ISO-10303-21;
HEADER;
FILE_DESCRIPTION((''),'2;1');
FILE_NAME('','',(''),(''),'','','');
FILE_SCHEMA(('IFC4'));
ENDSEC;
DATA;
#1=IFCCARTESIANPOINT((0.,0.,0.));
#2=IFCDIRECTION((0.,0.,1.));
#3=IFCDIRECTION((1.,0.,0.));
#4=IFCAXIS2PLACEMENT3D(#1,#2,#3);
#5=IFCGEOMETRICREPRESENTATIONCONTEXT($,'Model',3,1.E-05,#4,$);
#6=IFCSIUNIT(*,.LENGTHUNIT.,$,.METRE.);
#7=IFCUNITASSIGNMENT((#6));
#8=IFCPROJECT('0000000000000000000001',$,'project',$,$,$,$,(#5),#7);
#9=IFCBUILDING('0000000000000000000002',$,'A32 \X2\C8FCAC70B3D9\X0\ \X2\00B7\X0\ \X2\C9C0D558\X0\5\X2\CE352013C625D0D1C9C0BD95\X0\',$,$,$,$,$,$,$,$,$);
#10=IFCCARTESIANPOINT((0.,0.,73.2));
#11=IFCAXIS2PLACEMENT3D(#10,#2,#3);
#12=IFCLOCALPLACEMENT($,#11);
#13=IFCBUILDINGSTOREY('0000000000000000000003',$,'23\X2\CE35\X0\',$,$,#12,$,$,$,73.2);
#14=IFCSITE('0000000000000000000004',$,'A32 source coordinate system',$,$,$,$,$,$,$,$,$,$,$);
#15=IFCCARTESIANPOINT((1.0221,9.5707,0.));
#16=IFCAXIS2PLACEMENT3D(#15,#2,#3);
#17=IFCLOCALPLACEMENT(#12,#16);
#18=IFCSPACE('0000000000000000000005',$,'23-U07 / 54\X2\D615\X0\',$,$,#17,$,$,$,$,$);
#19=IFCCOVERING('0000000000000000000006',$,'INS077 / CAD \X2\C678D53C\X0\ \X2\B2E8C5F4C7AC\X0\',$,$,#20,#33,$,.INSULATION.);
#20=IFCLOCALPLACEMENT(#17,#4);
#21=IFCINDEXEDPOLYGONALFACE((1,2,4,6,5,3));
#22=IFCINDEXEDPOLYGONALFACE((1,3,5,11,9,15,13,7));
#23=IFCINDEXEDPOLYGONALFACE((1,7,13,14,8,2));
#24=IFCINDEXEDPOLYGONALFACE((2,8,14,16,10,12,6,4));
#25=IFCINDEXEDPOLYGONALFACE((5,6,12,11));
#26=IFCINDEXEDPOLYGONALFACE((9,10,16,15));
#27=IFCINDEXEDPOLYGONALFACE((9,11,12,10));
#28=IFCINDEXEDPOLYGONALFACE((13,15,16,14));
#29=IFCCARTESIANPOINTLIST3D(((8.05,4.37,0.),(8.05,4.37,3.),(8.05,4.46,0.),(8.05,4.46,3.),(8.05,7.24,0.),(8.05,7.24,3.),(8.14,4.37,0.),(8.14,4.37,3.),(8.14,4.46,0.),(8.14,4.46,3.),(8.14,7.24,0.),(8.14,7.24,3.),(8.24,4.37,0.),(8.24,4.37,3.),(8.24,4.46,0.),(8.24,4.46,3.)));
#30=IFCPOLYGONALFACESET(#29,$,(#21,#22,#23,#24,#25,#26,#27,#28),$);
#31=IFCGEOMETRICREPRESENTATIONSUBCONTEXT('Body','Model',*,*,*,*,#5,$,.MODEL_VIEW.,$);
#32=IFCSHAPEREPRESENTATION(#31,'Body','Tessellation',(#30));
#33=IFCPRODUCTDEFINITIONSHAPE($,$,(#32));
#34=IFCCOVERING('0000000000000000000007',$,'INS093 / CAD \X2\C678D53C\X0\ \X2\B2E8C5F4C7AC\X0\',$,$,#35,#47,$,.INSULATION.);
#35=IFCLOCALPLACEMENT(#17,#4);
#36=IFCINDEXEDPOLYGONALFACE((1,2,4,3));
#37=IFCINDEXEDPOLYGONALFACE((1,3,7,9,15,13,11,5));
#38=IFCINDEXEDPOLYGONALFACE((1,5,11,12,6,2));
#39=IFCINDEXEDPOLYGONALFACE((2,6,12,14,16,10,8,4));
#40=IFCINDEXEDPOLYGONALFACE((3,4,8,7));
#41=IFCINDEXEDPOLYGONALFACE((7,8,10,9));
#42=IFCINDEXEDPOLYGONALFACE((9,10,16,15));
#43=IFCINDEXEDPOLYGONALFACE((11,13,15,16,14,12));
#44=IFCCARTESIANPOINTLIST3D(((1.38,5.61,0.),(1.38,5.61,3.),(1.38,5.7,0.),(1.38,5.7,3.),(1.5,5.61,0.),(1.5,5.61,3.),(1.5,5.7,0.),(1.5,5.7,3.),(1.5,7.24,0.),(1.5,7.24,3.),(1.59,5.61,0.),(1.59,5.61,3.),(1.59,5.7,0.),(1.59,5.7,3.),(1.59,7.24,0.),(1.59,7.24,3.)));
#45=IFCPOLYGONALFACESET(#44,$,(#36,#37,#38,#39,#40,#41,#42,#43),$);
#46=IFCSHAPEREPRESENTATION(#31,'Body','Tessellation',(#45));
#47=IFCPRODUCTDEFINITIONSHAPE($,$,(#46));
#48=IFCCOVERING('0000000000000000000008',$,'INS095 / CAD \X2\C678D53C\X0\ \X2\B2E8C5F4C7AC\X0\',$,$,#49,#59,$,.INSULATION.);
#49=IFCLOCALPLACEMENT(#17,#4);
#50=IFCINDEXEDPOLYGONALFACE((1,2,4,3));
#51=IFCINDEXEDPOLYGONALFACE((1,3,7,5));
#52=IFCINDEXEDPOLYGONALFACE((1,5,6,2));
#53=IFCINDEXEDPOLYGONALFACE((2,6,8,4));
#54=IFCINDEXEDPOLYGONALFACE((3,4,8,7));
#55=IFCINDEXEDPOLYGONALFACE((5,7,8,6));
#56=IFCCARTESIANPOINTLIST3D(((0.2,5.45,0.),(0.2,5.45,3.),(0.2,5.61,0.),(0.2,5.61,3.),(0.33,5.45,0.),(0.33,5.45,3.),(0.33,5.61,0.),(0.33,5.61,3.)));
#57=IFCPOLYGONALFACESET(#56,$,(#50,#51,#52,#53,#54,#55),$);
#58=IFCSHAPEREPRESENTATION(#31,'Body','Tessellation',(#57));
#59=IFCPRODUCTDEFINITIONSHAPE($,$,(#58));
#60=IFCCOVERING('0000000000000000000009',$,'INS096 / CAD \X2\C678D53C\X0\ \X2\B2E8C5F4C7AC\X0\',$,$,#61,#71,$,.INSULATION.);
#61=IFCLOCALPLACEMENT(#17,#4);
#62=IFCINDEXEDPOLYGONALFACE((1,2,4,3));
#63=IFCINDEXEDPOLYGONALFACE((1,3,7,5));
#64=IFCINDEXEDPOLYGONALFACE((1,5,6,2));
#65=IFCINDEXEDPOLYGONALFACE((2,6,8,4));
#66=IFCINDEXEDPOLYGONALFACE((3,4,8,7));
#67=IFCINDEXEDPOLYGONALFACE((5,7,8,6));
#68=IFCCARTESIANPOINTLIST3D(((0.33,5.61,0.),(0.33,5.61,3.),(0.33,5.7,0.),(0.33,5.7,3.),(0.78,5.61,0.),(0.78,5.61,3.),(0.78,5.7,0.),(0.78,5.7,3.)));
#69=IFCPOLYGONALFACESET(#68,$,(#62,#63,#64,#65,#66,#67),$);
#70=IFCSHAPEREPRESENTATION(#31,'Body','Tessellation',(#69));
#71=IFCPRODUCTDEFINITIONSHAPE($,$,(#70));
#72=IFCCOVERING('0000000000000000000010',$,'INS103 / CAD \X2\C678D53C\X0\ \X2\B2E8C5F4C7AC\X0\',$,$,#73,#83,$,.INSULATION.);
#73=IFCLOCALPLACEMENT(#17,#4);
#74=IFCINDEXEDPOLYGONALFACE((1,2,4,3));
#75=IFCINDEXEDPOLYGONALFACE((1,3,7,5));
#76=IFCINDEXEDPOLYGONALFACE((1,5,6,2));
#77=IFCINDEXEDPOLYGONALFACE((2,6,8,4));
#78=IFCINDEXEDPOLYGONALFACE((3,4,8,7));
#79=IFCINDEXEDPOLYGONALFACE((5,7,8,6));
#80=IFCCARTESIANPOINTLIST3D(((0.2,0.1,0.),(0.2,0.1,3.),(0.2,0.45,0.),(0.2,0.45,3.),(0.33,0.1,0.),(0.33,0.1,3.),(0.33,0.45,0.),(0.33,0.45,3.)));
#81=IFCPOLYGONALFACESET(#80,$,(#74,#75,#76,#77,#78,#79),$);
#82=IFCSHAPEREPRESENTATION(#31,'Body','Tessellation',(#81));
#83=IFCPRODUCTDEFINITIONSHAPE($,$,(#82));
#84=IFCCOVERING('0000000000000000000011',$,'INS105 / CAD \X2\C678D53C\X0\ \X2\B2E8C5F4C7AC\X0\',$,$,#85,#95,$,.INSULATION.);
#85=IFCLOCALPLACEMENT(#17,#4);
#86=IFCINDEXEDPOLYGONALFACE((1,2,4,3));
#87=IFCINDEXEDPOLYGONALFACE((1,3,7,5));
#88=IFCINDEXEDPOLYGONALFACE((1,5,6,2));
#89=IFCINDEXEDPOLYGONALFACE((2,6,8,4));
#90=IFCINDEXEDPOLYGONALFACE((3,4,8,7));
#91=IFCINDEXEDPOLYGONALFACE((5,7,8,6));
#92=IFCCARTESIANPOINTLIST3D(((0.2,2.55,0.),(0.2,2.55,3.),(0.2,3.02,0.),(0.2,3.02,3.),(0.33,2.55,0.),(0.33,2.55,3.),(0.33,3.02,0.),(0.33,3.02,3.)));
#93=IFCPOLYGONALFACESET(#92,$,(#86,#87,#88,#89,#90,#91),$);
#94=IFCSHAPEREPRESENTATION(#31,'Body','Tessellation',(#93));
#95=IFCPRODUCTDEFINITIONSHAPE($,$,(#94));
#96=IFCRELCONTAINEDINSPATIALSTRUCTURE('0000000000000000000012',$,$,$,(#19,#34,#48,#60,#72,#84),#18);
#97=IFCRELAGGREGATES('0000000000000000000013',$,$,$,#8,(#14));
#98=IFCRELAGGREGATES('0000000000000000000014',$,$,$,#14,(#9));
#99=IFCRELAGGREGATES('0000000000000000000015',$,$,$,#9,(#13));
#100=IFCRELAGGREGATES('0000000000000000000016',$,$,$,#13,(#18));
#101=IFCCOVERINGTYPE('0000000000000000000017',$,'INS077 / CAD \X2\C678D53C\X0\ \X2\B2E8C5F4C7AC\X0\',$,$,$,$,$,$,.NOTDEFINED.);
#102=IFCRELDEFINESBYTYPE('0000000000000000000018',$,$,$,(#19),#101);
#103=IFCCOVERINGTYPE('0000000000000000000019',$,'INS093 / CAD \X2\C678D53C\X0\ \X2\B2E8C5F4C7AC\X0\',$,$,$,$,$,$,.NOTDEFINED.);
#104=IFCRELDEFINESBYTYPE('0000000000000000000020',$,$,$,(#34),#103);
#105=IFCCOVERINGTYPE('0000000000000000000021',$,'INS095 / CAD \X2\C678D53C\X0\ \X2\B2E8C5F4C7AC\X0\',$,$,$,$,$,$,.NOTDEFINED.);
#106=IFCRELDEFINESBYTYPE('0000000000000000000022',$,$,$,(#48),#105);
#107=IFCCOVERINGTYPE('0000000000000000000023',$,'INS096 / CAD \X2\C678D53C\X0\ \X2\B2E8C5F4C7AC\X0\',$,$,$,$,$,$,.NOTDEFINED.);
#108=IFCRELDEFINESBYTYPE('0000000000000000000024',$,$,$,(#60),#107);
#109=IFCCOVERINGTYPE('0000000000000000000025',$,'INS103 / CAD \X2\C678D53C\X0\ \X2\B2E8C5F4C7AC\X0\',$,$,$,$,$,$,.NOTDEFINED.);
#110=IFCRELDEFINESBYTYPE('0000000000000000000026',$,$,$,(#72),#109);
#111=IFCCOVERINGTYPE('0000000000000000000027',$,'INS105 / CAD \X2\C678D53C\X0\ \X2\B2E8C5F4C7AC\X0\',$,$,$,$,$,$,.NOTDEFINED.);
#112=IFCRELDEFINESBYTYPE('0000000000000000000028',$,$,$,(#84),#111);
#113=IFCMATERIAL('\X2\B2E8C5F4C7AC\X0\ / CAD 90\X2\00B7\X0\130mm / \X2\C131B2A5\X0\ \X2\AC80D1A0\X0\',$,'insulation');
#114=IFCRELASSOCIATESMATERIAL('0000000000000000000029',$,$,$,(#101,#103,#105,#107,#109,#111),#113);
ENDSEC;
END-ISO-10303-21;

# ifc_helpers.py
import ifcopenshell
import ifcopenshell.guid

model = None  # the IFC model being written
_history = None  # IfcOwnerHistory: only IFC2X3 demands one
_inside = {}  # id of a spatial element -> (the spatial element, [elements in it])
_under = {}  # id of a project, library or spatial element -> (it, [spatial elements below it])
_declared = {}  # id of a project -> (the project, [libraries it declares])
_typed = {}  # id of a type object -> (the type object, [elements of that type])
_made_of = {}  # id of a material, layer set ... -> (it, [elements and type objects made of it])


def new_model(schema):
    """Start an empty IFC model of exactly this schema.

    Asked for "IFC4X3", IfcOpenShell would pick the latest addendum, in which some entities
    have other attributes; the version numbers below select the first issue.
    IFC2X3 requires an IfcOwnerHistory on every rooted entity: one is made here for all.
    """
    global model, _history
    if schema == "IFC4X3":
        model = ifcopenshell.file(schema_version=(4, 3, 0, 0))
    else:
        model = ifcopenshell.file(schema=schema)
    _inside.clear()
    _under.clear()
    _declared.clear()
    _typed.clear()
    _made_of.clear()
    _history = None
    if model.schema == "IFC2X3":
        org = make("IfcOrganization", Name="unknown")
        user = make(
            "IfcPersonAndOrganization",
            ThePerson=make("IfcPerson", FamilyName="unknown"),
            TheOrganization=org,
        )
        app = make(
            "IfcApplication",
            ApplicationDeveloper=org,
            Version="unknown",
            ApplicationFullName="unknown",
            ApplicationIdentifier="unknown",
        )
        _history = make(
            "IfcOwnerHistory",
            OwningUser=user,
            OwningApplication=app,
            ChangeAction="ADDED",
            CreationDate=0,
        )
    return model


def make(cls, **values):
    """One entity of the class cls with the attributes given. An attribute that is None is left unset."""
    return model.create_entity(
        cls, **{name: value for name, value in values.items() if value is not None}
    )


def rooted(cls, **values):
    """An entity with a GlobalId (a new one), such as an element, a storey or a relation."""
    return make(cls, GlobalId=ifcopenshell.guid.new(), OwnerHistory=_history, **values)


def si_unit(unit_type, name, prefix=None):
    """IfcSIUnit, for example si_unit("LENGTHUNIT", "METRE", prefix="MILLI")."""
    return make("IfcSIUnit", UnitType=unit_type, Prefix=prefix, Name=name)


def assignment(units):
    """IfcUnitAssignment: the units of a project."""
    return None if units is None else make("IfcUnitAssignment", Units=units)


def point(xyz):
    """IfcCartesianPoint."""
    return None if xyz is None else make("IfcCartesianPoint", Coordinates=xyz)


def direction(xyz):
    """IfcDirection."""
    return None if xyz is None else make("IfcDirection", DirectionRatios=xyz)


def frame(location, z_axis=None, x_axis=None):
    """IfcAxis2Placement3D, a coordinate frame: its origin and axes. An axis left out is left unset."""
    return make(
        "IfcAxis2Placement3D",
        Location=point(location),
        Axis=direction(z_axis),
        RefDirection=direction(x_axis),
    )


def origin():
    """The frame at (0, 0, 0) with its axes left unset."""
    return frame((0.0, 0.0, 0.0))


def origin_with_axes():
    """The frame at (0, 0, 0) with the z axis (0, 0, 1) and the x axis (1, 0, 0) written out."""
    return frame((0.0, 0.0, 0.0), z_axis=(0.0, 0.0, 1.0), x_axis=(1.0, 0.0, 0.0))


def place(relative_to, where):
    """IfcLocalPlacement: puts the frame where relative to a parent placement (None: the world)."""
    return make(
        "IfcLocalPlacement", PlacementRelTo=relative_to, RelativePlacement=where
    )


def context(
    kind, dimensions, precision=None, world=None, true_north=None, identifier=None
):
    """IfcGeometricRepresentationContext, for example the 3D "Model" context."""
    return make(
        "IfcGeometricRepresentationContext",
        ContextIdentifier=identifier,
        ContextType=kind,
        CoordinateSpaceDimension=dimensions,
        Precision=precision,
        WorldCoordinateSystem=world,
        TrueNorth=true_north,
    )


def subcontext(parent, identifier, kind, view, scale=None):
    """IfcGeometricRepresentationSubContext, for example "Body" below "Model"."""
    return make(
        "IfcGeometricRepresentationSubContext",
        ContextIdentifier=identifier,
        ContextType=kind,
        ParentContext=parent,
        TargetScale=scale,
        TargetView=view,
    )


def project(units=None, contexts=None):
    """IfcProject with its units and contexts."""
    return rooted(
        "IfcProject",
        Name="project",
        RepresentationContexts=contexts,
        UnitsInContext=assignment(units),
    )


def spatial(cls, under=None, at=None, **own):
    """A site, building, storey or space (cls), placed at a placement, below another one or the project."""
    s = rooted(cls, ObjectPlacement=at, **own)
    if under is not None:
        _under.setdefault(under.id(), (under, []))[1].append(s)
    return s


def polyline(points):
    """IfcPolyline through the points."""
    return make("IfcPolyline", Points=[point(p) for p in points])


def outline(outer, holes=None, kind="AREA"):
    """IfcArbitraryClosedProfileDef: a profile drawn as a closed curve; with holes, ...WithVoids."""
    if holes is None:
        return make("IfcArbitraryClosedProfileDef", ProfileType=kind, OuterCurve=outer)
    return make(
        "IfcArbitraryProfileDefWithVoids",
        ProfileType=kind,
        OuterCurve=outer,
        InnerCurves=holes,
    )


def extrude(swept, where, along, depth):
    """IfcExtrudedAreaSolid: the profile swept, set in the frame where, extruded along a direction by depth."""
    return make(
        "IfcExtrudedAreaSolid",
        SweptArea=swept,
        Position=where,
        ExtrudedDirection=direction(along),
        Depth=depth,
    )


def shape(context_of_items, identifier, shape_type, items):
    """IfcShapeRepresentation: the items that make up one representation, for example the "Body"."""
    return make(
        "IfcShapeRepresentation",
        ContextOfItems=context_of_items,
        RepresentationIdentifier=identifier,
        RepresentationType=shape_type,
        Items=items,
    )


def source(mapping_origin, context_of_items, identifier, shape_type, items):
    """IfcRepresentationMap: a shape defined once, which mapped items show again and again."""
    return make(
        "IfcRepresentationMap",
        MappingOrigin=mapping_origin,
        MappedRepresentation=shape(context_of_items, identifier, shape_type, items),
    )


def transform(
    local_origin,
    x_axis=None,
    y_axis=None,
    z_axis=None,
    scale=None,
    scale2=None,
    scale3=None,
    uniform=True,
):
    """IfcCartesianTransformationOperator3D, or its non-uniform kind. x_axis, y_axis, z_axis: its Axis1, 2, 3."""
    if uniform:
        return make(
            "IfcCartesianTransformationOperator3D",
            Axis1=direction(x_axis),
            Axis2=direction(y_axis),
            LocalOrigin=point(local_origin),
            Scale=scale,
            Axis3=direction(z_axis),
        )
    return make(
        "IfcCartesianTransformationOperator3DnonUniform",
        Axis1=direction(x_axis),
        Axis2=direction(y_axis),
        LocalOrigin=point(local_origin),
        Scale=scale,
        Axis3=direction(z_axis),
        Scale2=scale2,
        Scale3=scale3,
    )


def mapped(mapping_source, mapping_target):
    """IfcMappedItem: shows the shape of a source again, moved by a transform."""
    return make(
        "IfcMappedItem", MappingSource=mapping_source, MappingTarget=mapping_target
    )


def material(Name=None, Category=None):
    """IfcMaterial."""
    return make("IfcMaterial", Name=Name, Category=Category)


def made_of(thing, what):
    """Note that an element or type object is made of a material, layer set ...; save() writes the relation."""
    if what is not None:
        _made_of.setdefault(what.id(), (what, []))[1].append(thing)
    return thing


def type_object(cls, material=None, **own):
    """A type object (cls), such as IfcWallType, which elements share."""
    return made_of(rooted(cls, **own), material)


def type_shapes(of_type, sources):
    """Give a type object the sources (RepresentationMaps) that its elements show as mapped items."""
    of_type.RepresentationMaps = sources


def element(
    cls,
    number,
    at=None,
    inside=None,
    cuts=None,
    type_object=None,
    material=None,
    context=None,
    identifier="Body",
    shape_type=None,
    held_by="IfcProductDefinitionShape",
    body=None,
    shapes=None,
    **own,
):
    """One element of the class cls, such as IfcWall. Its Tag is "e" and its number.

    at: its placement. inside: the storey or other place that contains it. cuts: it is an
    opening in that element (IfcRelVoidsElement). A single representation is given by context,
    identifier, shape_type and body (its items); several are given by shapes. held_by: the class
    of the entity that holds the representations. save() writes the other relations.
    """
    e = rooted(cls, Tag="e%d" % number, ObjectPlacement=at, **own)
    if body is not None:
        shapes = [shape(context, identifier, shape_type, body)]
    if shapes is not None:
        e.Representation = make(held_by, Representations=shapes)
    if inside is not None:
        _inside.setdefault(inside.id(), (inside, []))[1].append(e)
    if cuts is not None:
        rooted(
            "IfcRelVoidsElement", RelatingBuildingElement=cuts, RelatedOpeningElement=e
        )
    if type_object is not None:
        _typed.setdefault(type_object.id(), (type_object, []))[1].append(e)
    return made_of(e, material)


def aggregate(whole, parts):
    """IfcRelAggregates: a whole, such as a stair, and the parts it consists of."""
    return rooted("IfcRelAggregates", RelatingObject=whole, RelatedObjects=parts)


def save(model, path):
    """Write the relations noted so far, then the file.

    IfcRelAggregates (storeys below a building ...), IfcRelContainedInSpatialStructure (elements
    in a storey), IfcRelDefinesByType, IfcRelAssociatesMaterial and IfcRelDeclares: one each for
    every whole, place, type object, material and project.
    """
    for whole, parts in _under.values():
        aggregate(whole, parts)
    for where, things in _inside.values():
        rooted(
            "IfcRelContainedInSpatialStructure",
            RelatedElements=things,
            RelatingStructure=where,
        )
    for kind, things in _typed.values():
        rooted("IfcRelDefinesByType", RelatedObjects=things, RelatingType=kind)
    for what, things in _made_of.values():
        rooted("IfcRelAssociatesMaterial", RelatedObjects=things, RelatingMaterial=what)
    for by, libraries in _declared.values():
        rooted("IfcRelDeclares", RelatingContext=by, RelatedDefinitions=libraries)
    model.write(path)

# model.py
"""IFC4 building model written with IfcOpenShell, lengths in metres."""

from ifc_helpers import new_model, si_unit, frame, origin, origin_with_axes, place, context, subcontext, project, spatial, polyline, outline, extrude, source, transform, mapped, material, type_object, type_shapes, element, save


model = new_model("IFC4")

# Units and contexts
model_context = context("Model", 3, precision=1e-05, world=origin_with_axes())
body_context = subcontext(model_context, "Body", "Model", "MODEL_VIEW")
ifc_project = project(units=[si_unit("LENGTHUNIT", "METRE")], contexts=[model_context])

# Site, building, storey, space
storey_placement = place(None, frame((0.0, 0.0, 73.2), z_axis=(0.0, 0.0, 1.0), x_axis=(1.0, 0.0, 0.0)))
space_placement = place(storey_placement, frame((1.0221, 9.5707, 0.0), z_axis=(0.0, 0.0, 1.0), x_axis=(1.0, 0.0, 0.0)))
site = spatial("IfcSite", under=ifc_project, Name="A32 source coordinate system")
building = spatial("IfcBuilding", under=site, Name="A32 주거동 · 지하5층–옥탑지붕")
storey = spatial("IfcBuildingStorey", under=building, at=storey_placement, Name="23층", Elevation=73.2)
space = spatial("IfcSpace", under=storey, at=space_placement, Name="23-U07 / 54형")

# Coverings
ifc_material = material(Name="단열재 / CAD 90·130mm / 성능 검토", Category="insulation")
covering_type_1 = type_object("IfcCoveringType", Name="INS077 / CAD 외피 단열재", PredefinedType="NOTDEFINED", material=ifc_material)
shared_shape_1 = source(origin(), body_context, "Body", "SweptSolid", [
    extrude(outline(polyline([(8.24, 4.37), (8.14, 4.37), (8.05, 4.37), (8.05, 4.46), (8.05, 7.24), (8.14, 7.24), (8.14, 4.46), (8.24, 4.46), (8.24, 4.37)])), origin(), (0.0, 0.0, 1.0), 3.0),
])
type_shapes(covering_type_1, [shared_shape_1])
covering_1_placement = place(space_placement, origin_with_axes())
element("IfcCovering", 1, at=covering_1_placement, inside=space, type_object=covering_type_1, Name="INS077 / CAD 외피 단열재", PredefinedType="INSULATION", context=body_context, shape_type="MappedRepresentation", body=[
    mapped(shared_shape_1, transform((0.0, 0.0, 0.0), scale=1.0)),
])
covering_type_2 = type_object("IfcCoveringType", Name="INS093 / CAD 외피 단열재", PredefinedType="NOTDEFINED", material=ifc_material)
shared_shape_2 = source(origin(), body_context, "Body", "SweptSolid", [
    extrude(outline(polyline([(1.5, 5.7), (1.5, 7.24), (1.59, 7.24), (1.59, 5.7), (1.59, 5.61), (1.5, 5.61), (1.38, 5.61), (1.38, 5.7), (1.5, 5.7)])), origin(), (0.0, 0.0, 1.0), 3.0),
])
type_shapes(covering_type_2, [shared_shape_2])
covering_2_placement = place(space_placement, origin_with_axes())
element("IfcCovering", 2, at=covering_2_placement, inside=space, type_object=covering_type_2, Name="INS093 / CAD 외피 단열재", PredefinedType="INSULATION", context=body_context, shape_type="MappedRepresentation", body=[
    mapped(shared_shape_2, transform((0.0, 0.0, 0.0), scale=1.0)),
])
covering_type_3 = type_object("IfcCoveringType", Name="INS095 / CAD 외피 단열재", PredefinedType="NOTDEFINED", material=ifc_material)
shared_shape_3 = source(origin(), body_context, "Body", "SweptSolid", [
    extrude(outline(polyline([(0.2, 5.61), (0.33, 5.61), (0.33, 5.45), (0.2, 5.45), (0.2, 5.61)])), origin(), (0.0, 0.0, 1.0), 3.0),
])
type_shapes(covering_type_3, [shared_shape_3])
covering_3_placement = place(space_placement, origin_with_axes())
element("IfcCovering", 3, at=covering_3_placement, inside=space, type_object=covering_type_3, Name="INS095 / CAD 외피 단열재", PredefinedType="INSULATION", context=body_context, shape_type="MappedRepresentation", body=[
    mapped(shared_shape_3, transform((0.0, 0.0, 0.0), scale=1.0)),
])
covering_type_4 = type_object("IfcCoveringType", Name="INS096 / CAD 외피 단열재", PredefinedType="NOTDEFINED", material=ifc_material)
shared_shape_4 = source(origin(), body_context, "Body", "SweptSolid", [
    extrude(outline(polyline([(0.78, 5.7), (0.78, 5.61), (0.33, 5.61), (0.33, 5.7), (0.78, 5.7)])), origin(), (0.0, 0.0, 1.0), 3.0),
])
type_shapes(covering_type_4, [shared_shape_4])
covering_4_placement = place(space_placement, origin_with_axes())
element("IfcCovering", 4, at=covering_4_placement, inside=space, type_object=covering_type_4, Name="INS096 / CAD 외피 단열재", PredefinedType="INSULATION", context=body_context, shape_type="MappedRepresentation", body=[
    mapped(shared_shape_4, transform((0.0, 0.0, 0.0), scale=1.0)),
])
covering_type_5 = type_object("IfcCoveringType", Name="INS103 / CAD 외피 단열재", PredefinedType="NOTDEFINED", material=ifc_material)
shared_shape_5 = source(origin(), body_context, "Body", "SweptSolid", [
    extrude(outline(polyline([(0.2, 0.45), (0.33, 0.45), (0.33, 0.1), (0.2, 0.1), (0.2, 0.45)])), origin(), (0.0, 0.0, 1.0), 3.0),
])
type_shapes(covering_type_5, [shared_shape_5])
covering_5_placement = place(space_placement, origin_with_axes())
element("IfcCovering", 5, at=covering_5_placement, inside=space, type_object=covering_type_5, Name="INS103 / CAD 외피 단열재", PredefinedType="INSULATION", context=body_context, shape_type="MappedRepresentation", body=[
    mapped(shared_shape_5, transform((0.0, 0.0, 0.0), scale=1.0)),
])
covering_type_6 = type_object("IfcCoveringType", Name="INS105 / CAD 외피 단열재", PredefinedType="NOTDEFINED", material=ifc_material)
shared_shape_6 = source(origin(), body_context, "Body", "SweptSolid", [
    extrude(outline(polyline([(0.2, 3.02), (0.33, 3.02), (0.33, 2.55), (0.2, 2.55), (0.2, 3.02)])), origin(), (0.0, 0.0, 1.0), 3.0),
])
type_shapes(covering_type_6, [shared_shape_6])
covering_6_placement = place(space_placement, origin_with_axes())
element("IfcCovering", 6, at=covering_6_placement, inside=space, type_object=covering_type_6, Name="INS105 / CAD 외피 단열재", PredefinedType="INSULATION", context=body_context, shape_type="MappedRepresentation", body=[
    mapped(shared_shape_6, transform((0.0, 0.0, 0.0), scale=1.0)),
])

save(model, "model.ifc")
